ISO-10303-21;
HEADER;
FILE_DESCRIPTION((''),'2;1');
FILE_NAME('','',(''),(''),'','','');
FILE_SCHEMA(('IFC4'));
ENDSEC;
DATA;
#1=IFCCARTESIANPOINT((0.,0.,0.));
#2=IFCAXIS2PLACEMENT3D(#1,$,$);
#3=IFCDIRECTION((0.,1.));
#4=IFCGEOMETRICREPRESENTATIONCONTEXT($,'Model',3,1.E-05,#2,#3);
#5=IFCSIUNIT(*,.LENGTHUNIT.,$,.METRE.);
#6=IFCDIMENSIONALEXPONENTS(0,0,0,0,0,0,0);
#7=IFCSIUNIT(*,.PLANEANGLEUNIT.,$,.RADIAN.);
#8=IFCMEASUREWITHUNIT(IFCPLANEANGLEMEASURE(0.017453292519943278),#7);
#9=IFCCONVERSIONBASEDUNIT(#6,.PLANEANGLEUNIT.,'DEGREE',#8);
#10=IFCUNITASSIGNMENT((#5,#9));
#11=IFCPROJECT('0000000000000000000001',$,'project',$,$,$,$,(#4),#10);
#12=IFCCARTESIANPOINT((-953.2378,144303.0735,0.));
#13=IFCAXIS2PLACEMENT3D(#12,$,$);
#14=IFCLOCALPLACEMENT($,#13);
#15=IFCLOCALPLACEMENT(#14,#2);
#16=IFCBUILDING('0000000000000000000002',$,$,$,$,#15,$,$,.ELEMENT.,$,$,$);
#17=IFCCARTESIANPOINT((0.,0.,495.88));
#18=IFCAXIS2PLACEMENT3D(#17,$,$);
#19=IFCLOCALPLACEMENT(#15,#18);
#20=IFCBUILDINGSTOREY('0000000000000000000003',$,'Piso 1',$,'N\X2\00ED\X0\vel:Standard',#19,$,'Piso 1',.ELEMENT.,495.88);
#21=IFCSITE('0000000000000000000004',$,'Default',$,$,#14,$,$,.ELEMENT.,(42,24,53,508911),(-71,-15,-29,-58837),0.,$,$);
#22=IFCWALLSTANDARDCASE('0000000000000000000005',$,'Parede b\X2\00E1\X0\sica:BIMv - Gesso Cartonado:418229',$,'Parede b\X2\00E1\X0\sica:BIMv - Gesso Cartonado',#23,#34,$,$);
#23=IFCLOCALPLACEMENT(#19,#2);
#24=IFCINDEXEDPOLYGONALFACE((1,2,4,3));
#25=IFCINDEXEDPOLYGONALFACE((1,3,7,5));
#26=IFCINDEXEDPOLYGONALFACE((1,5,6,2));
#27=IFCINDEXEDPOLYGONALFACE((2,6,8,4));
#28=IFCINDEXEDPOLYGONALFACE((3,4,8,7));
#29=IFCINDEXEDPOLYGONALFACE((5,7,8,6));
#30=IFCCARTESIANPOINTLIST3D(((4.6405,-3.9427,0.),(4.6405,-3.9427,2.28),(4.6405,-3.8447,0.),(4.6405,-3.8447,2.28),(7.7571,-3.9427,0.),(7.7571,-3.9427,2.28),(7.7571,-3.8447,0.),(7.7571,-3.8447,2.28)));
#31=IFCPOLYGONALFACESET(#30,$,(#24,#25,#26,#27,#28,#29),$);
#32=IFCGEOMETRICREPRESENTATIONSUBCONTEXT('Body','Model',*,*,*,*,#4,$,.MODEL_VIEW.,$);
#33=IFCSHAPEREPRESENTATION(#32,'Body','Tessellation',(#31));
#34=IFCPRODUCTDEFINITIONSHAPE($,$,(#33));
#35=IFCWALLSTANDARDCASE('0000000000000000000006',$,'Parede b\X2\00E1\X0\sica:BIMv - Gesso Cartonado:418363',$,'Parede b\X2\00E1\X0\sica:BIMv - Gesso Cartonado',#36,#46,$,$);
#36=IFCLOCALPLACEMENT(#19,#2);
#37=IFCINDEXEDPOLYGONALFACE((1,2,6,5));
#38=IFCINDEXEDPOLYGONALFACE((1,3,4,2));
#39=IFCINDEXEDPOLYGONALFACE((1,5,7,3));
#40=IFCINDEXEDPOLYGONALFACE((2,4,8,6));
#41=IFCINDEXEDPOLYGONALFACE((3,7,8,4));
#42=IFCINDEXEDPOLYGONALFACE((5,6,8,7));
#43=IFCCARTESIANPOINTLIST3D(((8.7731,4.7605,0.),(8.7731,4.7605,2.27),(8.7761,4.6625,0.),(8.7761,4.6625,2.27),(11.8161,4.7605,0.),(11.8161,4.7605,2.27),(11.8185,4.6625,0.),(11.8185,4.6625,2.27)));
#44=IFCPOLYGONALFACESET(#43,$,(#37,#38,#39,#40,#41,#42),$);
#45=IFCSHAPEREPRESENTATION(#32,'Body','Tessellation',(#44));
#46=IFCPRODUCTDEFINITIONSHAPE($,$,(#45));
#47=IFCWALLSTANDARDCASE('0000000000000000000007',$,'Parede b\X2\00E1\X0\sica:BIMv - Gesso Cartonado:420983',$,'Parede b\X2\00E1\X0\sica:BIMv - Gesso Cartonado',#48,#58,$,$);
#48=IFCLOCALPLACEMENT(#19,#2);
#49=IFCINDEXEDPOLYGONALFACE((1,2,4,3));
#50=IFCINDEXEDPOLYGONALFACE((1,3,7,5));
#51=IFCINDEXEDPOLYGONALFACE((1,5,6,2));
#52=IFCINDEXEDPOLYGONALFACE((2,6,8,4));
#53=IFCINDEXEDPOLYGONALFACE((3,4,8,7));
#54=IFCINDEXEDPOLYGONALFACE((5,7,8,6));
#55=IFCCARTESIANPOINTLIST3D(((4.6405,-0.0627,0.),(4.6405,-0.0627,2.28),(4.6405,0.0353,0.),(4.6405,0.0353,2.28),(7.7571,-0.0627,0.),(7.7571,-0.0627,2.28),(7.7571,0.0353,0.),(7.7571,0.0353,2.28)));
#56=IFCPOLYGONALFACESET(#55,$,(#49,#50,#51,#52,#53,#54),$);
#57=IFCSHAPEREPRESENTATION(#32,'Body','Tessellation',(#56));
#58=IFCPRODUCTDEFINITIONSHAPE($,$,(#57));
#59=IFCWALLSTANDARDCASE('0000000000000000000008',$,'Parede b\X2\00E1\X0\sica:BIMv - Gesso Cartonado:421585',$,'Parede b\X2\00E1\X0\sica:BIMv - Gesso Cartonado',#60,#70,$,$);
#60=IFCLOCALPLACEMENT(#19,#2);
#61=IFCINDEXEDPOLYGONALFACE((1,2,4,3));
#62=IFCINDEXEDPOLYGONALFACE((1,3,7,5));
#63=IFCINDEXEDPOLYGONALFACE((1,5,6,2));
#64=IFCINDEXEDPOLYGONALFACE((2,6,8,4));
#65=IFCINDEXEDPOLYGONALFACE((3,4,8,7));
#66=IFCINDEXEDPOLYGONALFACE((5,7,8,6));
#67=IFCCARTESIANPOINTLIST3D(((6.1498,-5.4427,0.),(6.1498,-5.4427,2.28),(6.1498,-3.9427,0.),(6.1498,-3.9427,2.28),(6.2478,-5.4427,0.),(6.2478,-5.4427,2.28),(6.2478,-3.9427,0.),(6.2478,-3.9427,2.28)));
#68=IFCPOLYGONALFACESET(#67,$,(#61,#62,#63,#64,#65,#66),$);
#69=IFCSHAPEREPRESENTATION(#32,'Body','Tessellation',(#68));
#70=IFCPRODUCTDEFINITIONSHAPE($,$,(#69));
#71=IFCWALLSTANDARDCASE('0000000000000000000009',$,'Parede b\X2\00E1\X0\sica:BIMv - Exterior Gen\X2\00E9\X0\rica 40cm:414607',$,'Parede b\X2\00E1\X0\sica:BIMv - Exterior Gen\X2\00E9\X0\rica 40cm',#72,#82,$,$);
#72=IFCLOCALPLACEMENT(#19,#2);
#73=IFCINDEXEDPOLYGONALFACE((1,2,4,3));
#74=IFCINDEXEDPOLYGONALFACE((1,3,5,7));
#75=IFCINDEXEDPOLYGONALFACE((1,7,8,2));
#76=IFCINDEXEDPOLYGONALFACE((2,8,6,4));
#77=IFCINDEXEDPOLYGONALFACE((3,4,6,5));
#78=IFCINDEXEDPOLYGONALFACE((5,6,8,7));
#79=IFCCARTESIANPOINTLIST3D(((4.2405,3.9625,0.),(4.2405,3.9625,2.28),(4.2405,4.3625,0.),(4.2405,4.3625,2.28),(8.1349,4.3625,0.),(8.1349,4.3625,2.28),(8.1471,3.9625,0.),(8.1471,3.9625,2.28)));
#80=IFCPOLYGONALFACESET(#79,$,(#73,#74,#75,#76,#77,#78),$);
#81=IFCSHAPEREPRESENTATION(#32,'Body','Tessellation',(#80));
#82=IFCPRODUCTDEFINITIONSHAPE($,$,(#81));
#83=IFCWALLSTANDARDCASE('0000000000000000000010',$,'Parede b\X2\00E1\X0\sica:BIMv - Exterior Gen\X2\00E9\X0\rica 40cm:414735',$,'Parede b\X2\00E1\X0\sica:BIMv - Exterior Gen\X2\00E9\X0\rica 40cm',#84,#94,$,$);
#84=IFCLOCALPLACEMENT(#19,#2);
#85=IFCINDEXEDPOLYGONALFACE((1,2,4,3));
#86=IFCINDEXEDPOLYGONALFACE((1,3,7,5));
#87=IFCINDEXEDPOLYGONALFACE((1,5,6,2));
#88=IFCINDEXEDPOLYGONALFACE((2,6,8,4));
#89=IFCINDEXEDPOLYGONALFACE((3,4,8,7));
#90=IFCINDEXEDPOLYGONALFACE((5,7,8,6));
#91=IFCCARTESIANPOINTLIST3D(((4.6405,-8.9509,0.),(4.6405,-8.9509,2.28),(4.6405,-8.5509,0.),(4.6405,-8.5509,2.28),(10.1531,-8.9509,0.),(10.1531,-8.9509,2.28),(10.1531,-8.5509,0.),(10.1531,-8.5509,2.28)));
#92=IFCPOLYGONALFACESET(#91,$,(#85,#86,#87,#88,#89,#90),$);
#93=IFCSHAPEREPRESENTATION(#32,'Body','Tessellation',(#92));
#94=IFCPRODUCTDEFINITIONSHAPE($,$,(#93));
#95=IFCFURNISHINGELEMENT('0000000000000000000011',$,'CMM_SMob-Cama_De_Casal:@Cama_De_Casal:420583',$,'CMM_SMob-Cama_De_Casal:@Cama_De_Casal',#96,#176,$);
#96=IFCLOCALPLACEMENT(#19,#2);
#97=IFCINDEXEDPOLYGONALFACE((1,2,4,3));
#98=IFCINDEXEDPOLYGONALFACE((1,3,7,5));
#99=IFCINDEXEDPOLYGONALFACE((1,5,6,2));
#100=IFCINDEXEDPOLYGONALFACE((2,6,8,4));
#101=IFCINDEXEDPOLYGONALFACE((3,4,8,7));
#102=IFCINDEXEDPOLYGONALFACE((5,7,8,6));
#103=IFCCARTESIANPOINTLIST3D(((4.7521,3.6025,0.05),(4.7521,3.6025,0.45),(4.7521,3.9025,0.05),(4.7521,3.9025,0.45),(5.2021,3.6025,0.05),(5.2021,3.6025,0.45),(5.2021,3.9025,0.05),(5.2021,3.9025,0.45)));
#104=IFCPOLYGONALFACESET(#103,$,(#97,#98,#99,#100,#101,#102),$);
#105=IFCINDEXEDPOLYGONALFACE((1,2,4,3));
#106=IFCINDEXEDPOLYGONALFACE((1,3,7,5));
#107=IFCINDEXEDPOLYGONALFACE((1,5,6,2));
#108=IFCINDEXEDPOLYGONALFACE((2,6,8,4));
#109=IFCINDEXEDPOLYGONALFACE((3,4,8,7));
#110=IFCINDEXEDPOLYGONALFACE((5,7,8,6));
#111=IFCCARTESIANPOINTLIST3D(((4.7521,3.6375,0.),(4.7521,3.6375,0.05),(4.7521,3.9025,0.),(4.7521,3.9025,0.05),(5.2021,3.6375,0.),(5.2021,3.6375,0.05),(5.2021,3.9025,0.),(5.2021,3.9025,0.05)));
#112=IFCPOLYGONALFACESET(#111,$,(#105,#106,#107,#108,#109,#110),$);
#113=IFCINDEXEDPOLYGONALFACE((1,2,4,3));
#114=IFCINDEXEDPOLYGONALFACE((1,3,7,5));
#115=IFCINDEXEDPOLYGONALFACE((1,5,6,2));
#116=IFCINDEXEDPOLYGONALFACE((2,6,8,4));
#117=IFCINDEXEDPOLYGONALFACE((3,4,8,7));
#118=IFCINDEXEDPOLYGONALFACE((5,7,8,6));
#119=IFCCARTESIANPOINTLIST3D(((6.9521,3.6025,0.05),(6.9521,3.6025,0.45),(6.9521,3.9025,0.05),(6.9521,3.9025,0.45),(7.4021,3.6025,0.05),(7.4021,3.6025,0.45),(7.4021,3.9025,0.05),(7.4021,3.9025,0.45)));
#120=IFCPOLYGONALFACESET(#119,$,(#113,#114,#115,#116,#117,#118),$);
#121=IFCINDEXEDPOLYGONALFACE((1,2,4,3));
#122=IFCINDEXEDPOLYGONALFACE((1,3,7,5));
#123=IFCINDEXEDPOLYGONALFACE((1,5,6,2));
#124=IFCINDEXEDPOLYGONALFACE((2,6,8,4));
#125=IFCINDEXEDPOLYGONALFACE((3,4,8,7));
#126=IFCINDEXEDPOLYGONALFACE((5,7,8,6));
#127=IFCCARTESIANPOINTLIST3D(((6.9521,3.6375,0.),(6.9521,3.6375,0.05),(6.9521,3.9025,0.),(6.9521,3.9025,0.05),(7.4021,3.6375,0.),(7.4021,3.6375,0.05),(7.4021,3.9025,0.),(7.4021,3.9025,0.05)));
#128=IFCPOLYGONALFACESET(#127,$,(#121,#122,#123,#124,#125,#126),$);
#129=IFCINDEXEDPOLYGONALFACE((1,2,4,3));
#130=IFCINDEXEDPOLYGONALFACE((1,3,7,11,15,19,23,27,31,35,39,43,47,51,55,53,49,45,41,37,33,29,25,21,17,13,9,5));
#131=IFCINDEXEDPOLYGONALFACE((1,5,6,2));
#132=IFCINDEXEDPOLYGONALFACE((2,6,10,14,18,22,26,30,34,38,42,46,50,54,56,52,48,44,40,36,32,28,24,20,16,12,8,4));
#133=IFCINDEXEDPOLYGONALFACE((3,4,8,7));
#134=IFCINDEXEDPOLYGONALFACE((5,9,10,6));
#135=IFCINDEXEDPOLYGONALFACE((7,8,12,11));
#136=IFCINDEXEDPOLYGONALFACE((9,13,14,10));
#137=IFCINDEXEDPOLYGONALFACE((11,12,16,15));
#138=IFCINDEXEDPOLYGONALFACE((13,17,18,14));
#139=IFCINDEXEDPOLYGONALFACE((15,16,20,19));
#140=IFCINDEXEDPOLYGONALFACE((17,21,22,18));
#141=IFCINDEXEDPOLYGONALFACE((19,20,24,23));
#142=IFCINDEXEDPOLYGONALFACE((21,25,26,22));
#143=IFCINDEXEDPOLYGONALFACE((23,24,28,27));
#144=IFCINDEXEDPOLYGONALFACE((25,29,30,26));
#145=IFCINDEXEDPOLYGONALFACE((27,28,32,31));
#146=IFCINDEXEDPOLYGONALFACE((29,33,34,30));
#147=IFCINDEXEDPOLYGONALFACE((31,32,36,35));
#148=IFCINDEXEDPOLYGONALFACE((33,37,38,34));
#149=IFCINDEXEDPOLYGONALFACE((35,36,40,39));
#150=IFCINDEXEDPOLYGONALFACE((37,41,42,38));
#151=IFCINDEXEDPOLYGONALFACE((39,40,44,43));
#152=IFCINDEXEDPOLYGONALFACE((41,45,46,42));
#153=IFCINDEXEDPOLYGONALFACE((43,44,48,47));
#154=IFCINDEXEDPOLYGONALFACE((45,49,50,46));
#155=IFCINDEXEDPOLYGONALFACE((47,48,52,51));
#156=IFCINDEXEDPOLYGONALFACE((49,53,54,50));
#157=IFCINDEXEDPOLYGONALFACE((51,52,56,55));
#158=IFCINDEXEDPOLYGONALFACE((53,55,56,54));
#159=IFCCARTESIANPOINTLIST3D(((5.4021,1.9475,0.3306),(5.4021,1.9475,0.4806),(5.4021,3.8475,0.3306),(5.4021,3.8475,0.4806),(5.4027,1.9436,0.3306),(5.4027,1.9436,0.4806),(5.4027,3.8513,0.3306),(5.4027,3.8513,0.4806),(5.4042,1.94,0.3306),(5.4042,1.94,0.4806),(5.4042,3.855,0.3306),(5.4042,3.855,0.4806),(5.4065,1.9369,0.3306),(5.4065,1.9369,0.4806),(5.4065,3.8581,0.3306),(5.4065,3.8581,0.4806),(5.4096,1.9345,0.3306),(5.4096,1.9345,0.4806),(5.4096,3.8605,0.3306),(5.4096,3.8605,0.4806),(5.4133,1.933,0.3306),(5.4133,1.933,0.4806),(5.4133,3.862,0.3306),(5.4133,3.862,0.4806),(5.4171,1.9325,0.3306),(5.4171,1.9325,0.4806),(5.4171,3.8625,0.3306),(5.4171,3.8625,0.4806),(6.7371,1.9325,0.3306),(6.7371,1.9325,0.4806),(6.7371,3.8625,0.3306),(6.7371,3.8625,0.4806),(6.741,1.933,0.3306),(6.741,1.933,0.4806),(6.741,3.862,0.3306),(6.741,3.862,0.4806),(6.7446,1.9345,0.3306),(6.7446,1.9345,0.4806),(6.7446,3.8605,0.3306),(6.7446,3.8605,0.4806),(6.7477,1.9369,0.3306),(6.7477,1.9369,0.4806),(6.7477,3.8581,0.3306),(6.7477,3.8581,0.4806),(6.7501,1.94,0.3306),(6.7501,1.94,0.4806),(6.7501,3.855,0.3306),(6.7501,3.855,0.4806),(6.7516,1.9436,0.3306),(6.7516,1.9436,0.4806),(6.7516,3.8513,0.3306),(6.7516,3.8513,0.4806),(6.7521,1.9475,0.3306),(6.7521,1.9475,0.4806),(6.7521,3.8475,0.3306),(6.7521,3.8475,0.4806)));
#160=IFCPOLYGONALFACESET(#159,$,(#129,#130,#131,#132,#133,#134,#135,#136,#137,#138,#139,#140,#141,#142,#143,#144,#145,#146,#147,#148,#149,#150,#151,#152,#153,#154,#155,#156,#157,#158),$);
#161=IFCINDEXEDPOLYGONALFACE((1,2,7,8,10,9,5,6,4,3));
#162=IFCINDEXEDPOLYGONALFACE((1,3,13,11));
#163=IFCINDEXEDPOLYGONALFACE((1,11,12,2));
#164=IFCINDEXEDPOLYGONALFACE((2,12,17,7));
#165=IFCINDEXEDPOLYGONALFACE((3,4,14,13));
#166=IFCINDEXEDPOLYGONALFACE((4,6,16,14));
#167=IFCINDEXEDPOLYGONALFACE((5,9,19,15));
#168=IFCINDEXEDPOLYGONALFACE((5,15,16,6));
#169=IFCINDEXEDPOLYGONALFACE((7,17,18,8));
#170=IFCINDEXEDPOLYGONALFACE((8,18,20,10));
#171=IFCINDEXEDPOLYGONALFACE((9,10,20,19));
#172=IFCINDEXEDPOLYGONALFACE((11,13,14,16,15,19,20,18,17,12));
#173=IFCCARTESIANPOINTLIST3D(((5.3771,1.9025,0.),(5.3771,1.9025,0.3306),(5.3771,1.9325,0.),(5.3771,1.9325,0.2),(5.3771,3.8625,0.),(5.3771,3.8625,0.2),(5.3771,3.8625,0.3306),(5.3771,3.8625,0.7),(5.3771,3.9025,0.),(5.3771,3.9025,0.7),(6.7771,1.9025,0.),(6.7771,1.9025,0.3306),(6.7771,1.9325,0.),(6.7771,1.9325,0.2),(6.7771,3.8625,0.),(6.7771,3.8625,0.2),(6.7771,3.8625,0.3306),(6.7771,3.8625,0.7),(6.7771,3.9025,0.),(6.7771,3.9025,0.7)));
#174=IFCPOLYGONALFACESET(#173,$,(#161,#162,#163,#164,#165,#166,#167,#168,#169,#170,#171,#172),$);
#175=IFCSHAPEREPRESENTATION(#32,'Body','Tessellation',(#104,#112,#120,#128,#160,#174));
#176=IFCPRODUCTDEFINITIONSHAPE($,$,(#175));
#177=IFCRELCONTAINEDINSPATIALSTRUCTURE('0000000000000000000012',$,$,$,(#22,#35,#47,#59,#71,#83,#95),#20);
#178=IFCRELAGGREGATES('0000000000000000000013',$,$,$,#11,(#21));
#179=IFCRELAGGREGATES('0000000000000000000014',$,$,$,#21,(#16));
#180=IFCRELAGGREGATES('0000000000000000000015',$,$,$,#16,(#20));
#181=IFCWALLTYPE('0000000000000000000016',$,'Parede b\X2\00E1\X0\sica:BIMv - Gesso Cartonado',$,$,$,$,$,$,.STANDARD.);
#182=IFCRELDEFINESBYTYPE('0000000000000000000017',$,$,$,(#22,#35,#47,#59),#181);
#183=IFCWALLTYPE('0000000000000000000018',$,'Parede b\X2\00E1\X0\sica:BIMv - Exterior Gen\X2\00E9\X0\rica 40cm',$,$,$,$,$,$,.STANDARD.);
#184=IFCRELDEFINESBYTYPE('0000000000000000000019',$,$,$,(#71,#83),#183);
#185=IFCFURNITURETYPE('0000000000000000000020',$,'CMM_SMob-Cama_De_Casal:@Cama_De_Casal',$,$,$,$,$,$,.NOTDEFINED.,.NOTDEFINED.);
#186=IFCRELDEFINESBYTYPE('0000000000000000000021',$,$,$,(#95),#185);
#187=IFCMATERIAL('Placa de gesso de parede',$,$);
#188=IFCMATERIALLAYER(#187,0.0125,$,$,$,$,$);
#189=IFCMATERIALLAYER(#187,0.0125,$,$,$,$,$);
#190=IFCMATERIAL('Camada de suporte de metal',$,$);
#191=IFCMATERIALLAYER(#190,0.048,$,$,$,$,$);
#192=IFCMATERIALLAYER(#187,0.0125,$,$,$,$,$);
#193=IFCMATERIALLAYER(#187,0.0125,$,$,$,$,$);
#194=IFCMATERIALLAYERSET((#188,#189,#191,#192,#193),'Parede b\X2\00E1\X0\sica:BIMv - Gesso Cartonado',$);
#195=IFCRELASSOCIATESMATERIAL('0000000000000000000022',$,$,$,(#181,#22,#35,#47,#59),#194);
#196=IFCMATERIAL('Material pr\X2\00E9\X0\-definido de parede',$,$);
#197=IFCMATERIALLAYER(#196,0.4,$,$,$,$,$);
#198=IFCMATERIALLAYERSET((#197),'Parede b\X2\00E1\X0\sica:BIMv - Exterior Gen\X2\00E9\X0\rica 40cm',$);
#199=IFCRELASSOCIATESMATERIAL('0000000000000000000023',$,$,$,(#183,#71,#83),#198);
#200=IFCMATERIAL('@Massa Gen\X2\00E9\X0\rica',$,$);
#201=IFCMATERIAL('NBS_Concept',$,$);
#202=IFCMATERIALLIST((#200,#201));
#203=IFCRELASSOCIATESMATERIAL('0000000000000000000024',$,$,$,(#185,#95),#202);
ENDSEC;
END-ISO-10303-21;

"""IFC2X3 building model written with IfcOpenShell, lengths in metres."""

from ifc_helpers import new_model, entity, si_unit, converted_unit, direction, frame, frame_2d, origin, origin_2d_with_axis, place, context, subcontext, project, spatial, polyline, circle_curve, parameter, trimmed, segment, composite_curve, rectangle, outline, extrude, clip, bounded_halfspace, source, transform, mapped, material, material_list, layer, layer_set, layer_usage, type_object, type_shapes, element, save


model = new_model("IFC2X3")

# Units and contexts
model_context = context("Model", 3, precision=1e-05, world=origin(), true_north=direction((0.0, 1.0)))
body_context = subcontext(model_context, "Body", "Model", "MODEL_VIEW")
ifc_project = project(units=[si_unit("LENGTHUNIT", "METRE"), converted_unit("PLANEANGLEUNIT", "DEGREE", entity("IfcPlaneAngleMeasure", 0.017453292519943278), si_unit("PLANEANGLEUNIT", "RADIAN"), dimensions=[0, 0, 0, 0, 0, 0, 0])], contexts=[model_context])

# Site, building, storey
site_placement = place(None, frame((-953.2378, 144303.0735, 0.0)))
site = spatial("IfcSite", under=ifc_project, at=site_placement, Name="Default", CompositionType="ELEMENT", RefLatitude=(42, 24, 53, 508911), RefLongitude=(-71, -15, -29, -58837), RefElevation=0.0)
building_placement = place(site_placement, origin())
building = spatial("IfcBuilding", under=site, at=building_placement, CompositionType="ELEMENT")
storey_placement = place(building_placement, frame((0.0, 0.0, 495.88)))
storey = spatial("IfcBuildingStorey", under=building, at=storey_placement, Name="Piso 1", ObjectType="Nível:Standard", LongName="Piso 1", CompositionType="ELEMENT", Elevation=495.88)

# Shared definitions
ifc_material_1 = material(Name="Material pré-definido de parede")

# Shared definitions
ifc_material_2 = material(Name="Placa de gesso de parede")
ifc_layer_1 = layer(ifc_material_2, 0.0125)
ifc_layer_2 = layer(ifc_material_2, 0.0125)
ifc_material_3 = material(Name="Camada de suporte de metal")
ifc_layer_3 = layer(ifc_material_3, 0.048)
ifc_layer_4 = layer(ifc_material_2, 0.0125)
ifc_layer_5 = layer(ifc_material_2, 0.0125)
ifc_layer_set_1 = layer_set([ifc_layer_1, ifc_layer_2, ifc_layer_3, ifc_layer_4, ifc_layer_5], Name="Parede básica:BIMv - Gesso Cartonado")
wall_type_1 = type_object("IfcWallType", Name="Parede básica:BIMv - Gesso Cartonado", PredefinedType="STANDARD", material=ifc_layer_set_1)

# Walls
ifc_layer_usage_1 = layer_usage(ifc_layer_set_1, "AXIS2", "NEGATIVE", 0.049)
wall_1_placement = place(storey_placement, frame((7.7571, -3.8937, 0.0), z_axis=(0.0, 0.0, 1.0), x_axis=(-1.0, 0.0, 0.0)))
element("IfcWallStandardCase", 1, at=wall_1_placement, inside=storey, type_object=wall_type_1, material=ifc_layer_usage_1, Name="Parede básica:BIMv - Gesso Cartonado:418229", ObjectType="Parede básica:BIMv - Gesso Cartonado", context=body_context, shape_type="Clipping", body=[
    clip(extrude(rectangle(XDim=3.1167, YDim=0.098, at=frame_2d((1.5583, 0.0), x_axis=(-1.0, 0.0))), origin(), (0.0, 0.0, 1.0), 2.28), bounded_halfspace(frame((0.0, -0.049, 2.28), z_axis=(0.0, 0.0, -1.0), x_axis=(-0.030399, 0.999538, 0.0)), True, frame((0.0, -0.049, 2.28)), polyline([(0.0, 0.0), (3.1167, 0.0), (3.1167, 0.098), (1.6073, 0.098), (1.5093, 0.098), (0.0, 0.098), (0.0, 0.0)]))),
])
ifc_layer_usage_2 = layer_usage(ifc_layer_set_1, "AXIS2", "NEGATIVE", 0.049)
wall_2_placement = place(storey_placement, frame((8.7731, 4.7115, 0.0)))
element("IfcWallStandardCase", 2, at=wall_2_placement, inside=storey, type_object=wall_type_1, material=ifc_layer_usage_2, Name="Parede básica:BIMv - Gesso Cartonado:418363", ObjectType="Parede básica:BIMv - Gesso Cartonado", context=body_context, shape_type="SweptSolid", body=[
    extrude(outline(polyline([(3.0454, -0.049), (3.043, 0.049), (0.0, 0.049), (0.003, -0.049), (3.0454, -0.049)])), origin(), (0.0, 0.0, 1.0), 2.27),
])
ifc_layer_usage_3 = layer_usage(ifc_layer_set_1, "AXIS2", "NEGATIVE", 0.049)
wall_3_placement = place(storey_placement, frame((4.6405, -0.0137, 0.0)))
element("IfcWallStandardCase", 3, at=wall_3_placement, inside=storey, type_object=wall_type_1, material=ifc_layer_usage_3, Name="Parede básica:BIMv - Gesso Cartonado:420983", ObjectType="Parede básica:BIMv - Gesso Cartonado", context=body_context, shape_type="Clipping", body=[
    clip(extrude(rectangle(XDim=3.1167, YDim=0.098, at=frame_2d((1.5583, 0.0), x_axis=(-1.0, 0.0))), origin(), (0.0, 0.0, 1.0), 2.28), bounded_halfspace(frame((0.0, -0.049, 2.28), z_axis=(0.0, 0.0, -1.0), x_axis=(0.030399, -0.999538, 0.0)), True, frame((0.0, -0.049, 2.28)), polyline([(0.0, 0.0), (3.1167, 0.0), (3.1167, 0.098), (0.0, 0.098), (0.0, 0.0)]))),
])
ifc_layer_usage_4 = layer_usage(ifc_layer_set_1, "AXIS2", "NEGATIVE", 0.049)
wall_4_placement = place(storey_placement, frame((6.1988, -3.9427, 0.0), z_axis=(0.0, 0.0, 1.0), x_axis=(0.0, -1.0, 0.0)))
element("IfcWallStandardCase", 4, at=wall_4_placement, inside=storey, type_object=wall_type_1, material=ifc_layer_usage_4, Name="Parede básica:BIMv - Gesso Cartonado:421585", ObjectType="Parede básica:BIMv - Gesso Cartonado", context=body_context, shape_type="Clipping", body=[
    clip(extrude(rectangle(XDim=1.5, YDim=0.098, at=frame_2d((0.75, 0.0), x_axis=(-1.0, 0.0))), origin(), (0.0, 0.0, 1.0), 2.28), bounded_halfspace(frame((0.0, -0.049, 2.28), z_axis=(0.0, 0.0, -1.0), x_axis=(0.999538, 0.030399, 0.0)), True, frame((0.0, -0.049, 2.28)), polyline([(0.0, 0.0), (1.5, 0.0), (1.5, 0.098), (0.0, 0.098), (0.0, 0.0)]))),
])
ifc_layer_6 = layer(ifc_material_1, 0.4)
ifc_layer_set_2 = layer_set([ifc_layer_6], Name="Parede básica:BIMv - Exterior Genérica 40cm")
ifc_layer_usage_5 = layer_usage(ifc_layer_set_2, "AXIS2", "POSITIVE", -0.2)
wall_type_2 = type_object("IfcWallType", Name="Parede básica:BIMv - Exterior Genérica 40cm", PredefinedType="STANDARD", material=ifc_layer_set_2)
wall_5_placement = place(storey_placement, frame((8.1471, 4.1625, 0.0), z_axis=(0.0, 0.0, 1.0), x_axis=(-1.0, 0.0, 0.0)))
element("IfcWallStandardCase", 5, at=wall_5_placement, inside=storey, type_object=wall_type_2, material=ifc_layer_usage_5, Name="Parede básica:BIMv - Exterior Genérica 40cm:414607", ObjectType="Parede básica:BIMv - Exterior Genérica 40cm", context=body_context, shape_type="Clipping", body=[
    clip(extrude(outline(polyline([(3.9066, -0.2), (3.9066, 0.2), (3.5066, 0.2), (0.0, 0.2), (0.0122, -0.2), (3.9066, -0.2)])), origin(), (0.0, 0.0, 1.0), 2.28), bounded_halfspace(frame((0.0122, -0.2, 2.28), z_axis=(0.0, 0.0, -1.0), x_axis=(-0.030399, 0.999538, 0.0)), True, frame((0.0122, -0.2, 2.28)), polyline([(0.0, 0.0), (3.8944, 0.0), (3.8944, 0.4), (3.4944, 0.4), (-0.0122, 0.4), (0.0, 0.0)]))),
])
ifc_layer_usage_6 = layer_usage(ifc_layer_set_2, "AXIS2", "POSITIVE", -0.2)
wall_6_placement = place(storey_placement, frame((4.6405, -8.7509, 0.0)))
element("IfcWallStandardCase", 6, at=wall_6_placement, inside=storey, type_object=wall_type_2, material=ifc_layer_usage_6, Name="Parede básica:BIMv - Exterior Genérica 40cm:414735", ObjectType="Parede básica:BIMv - Exterior Genérica 40cm", context=body_context, shape_type="Clipping", body=[
    clip(extrude(rectangle(XDim=5.5127, YDim=0.4, at=frame_2d((2.7563, 0.0), x_axis=(-1.0, 0.0))), origin(), (0.0, 0.0, 1.0), 2.28), bounded_halfspace(frame((0.0, -0.2, 2.28), z_axis=(0.0, 0.0, -1.0), x_axis=(0.030399, -0.999538, 0.0)), True, frame((0.0, -0.2, 2.28)), polyline([(0.0, 0.0), (5.5127, 0.0), (5.5127, 0.4), (0.0, 0.4), (0.0, 0.0)]))),
])

# Furnishing element
ifc_material_4 = material(Name="@Massa Genérica")
ifc_material_5 = material(Name="NBS_Concept")
ifc_material_list = material_list([ifc_material_4, ifc_material_5])
furniture_type_1 = type_object("IfcFurnitureType", Name="CMM_SMob-Cama_De_Casal:@Cama_De_Casal", AssemblyPlace="NOTDEFINED", material=ifc_material_list)
shared_shape_1 = source(origin(), body_context, "Body", "SweptSolid", [
    extrude(rectangle(XDim=0.3, YDim=0.45, at=origin_2d_with_axis()), frame((-1.1, -0.15, 0.05), z_axis=(0.0, 0.0, 1.0), x_axis=(0.0, 1.0, 0.0)), (0.0, 0.0, 1.0), 0.4),
    extrude(rectangle(XDim=0.265, YDim=0.45, at=frame_2d((0.0, 0.0), x_axis=(1.0, 0.0))), frame((-1.1, -0.1325, 0.0), z_axis=(0.0, 0.0, 1.0), x_axis=(0.0, -1.0, 0.0)), (0.0, 0.0, 1.0), 0.05),
    extrude(rectangle(XDim=0.45, YDim=0.3, at=frame_2d((0.0, 0.0), x_axis=(1.0, 0.0))), frame((1.1, -0.15, 0.05)), (0.0, 0.0, 1.0), 0.4),
    extrude(rectangle(XDim=0.45, YDim=0.265, at=origin_2d_with_axis()), frame((1.1, -0.1325, 0.0), z_axis=(0.0, 0.0, 1.0), x_axis=(-1.0, 0.0, 0.0)), (0.0, 0.0, 1.0), 0.05),
    extrude(outline(composite_curve([segment(polyline([(-0.66, -0.965), (0.66, -0.965)]), True, "CONTINUOUS"), segment(trimmed(circle_curve(frame_2d((0.66, -0.95), x_axis=(-1.0, 0.0)), 0.015), [parameter(90.0)], [parameter(180.0)], True, "PARAMETER"), True, "CONTINUOUS"), segment(polyline([(0.675, -0.95), (0.675, 0.95)]), True, "CONTINUOUS"), segment(trimmed(circle_curve(frame_2d((0.66, 0.95), x_axis=(-1.0, 0.0)), 0.015), [parameter(180.0)], [parameter(270.0)], True, "PARAMETER"), True, "CONTINUOUS"), segment(polyline([(0.66, 0.965), (-0.66, 0.965)]), True, "CONTINUOUS"), segment(trimmed(circle_curve(frame_2d((-0.66, 0.95), x_axis=(-1.0, 0.0)), 0.015), [parameter(270.0)], [parameter(0.0)], True, "PARAMETER"), True, "CONTINUOUS"), segment(polyline([(-0.675, 0.95), (-0.675, -0.95)]), True, "CONTINUOUS"), segment(trimmed(circle_curve(frame_2d((-0.66, -0.95), x_axis=(-1.0, 0.0)), 0.015), [parameter(0.0)], [parameter(90.0)], True, "PARAMETER"), True, "CONTINUOUS")], self_intersect=False)), frame((0.0, -1.005, 0.3306), z_axis=(0.0, 0.0, 1.0), x_axis=(-1.0, 0.0, 0.0)), (0.0, 0.0, 1.0), 0.15),
    extrude(outline(polyline([(-0.2461, -1.16), (-0.2461, -1.19), (0.0845, -1.19), (0.0845, 0.77), (0.4539, 0.77), (0.4539, 0.81), (-0.2461, 0.81), (-0.2461, 0.77), (-0.0461, 0.77), (-0.0461, -1.16), (-0.2461, -1.16)])), frame((-0.7, -0.81, 0.2461), z_axis=(-1.0, 0.0, 0.0), x_axis=(0.0, 0.0, 1.0)), (0.0, 0.0, -1.0), 1.4),
])
type_shapes(furniture_type_1, [shared_shape_1])
furnishing_1_placement = place(storey_placement, frame((6.0771, 3.9025, 0.0)))
element("IfcFurnishingElement", 7, at=furnishing_1_placement, inside=storey, type_object=furniture_type_1, material=ifc_material_list, Name="CMM_SMob-Cama_De_Casal:@Cama_De_Casal:420583", ObjectType="CMM_SMob-Cama_De_Casal:@Cama_De_Casal", context=body_context, shape_type="MappedRepresentation", body=[
    mapped(shared_shape_1, transform((0.0, 0.0, 0.0), scale=1.0)),
])

save(model, "model.ifc")
